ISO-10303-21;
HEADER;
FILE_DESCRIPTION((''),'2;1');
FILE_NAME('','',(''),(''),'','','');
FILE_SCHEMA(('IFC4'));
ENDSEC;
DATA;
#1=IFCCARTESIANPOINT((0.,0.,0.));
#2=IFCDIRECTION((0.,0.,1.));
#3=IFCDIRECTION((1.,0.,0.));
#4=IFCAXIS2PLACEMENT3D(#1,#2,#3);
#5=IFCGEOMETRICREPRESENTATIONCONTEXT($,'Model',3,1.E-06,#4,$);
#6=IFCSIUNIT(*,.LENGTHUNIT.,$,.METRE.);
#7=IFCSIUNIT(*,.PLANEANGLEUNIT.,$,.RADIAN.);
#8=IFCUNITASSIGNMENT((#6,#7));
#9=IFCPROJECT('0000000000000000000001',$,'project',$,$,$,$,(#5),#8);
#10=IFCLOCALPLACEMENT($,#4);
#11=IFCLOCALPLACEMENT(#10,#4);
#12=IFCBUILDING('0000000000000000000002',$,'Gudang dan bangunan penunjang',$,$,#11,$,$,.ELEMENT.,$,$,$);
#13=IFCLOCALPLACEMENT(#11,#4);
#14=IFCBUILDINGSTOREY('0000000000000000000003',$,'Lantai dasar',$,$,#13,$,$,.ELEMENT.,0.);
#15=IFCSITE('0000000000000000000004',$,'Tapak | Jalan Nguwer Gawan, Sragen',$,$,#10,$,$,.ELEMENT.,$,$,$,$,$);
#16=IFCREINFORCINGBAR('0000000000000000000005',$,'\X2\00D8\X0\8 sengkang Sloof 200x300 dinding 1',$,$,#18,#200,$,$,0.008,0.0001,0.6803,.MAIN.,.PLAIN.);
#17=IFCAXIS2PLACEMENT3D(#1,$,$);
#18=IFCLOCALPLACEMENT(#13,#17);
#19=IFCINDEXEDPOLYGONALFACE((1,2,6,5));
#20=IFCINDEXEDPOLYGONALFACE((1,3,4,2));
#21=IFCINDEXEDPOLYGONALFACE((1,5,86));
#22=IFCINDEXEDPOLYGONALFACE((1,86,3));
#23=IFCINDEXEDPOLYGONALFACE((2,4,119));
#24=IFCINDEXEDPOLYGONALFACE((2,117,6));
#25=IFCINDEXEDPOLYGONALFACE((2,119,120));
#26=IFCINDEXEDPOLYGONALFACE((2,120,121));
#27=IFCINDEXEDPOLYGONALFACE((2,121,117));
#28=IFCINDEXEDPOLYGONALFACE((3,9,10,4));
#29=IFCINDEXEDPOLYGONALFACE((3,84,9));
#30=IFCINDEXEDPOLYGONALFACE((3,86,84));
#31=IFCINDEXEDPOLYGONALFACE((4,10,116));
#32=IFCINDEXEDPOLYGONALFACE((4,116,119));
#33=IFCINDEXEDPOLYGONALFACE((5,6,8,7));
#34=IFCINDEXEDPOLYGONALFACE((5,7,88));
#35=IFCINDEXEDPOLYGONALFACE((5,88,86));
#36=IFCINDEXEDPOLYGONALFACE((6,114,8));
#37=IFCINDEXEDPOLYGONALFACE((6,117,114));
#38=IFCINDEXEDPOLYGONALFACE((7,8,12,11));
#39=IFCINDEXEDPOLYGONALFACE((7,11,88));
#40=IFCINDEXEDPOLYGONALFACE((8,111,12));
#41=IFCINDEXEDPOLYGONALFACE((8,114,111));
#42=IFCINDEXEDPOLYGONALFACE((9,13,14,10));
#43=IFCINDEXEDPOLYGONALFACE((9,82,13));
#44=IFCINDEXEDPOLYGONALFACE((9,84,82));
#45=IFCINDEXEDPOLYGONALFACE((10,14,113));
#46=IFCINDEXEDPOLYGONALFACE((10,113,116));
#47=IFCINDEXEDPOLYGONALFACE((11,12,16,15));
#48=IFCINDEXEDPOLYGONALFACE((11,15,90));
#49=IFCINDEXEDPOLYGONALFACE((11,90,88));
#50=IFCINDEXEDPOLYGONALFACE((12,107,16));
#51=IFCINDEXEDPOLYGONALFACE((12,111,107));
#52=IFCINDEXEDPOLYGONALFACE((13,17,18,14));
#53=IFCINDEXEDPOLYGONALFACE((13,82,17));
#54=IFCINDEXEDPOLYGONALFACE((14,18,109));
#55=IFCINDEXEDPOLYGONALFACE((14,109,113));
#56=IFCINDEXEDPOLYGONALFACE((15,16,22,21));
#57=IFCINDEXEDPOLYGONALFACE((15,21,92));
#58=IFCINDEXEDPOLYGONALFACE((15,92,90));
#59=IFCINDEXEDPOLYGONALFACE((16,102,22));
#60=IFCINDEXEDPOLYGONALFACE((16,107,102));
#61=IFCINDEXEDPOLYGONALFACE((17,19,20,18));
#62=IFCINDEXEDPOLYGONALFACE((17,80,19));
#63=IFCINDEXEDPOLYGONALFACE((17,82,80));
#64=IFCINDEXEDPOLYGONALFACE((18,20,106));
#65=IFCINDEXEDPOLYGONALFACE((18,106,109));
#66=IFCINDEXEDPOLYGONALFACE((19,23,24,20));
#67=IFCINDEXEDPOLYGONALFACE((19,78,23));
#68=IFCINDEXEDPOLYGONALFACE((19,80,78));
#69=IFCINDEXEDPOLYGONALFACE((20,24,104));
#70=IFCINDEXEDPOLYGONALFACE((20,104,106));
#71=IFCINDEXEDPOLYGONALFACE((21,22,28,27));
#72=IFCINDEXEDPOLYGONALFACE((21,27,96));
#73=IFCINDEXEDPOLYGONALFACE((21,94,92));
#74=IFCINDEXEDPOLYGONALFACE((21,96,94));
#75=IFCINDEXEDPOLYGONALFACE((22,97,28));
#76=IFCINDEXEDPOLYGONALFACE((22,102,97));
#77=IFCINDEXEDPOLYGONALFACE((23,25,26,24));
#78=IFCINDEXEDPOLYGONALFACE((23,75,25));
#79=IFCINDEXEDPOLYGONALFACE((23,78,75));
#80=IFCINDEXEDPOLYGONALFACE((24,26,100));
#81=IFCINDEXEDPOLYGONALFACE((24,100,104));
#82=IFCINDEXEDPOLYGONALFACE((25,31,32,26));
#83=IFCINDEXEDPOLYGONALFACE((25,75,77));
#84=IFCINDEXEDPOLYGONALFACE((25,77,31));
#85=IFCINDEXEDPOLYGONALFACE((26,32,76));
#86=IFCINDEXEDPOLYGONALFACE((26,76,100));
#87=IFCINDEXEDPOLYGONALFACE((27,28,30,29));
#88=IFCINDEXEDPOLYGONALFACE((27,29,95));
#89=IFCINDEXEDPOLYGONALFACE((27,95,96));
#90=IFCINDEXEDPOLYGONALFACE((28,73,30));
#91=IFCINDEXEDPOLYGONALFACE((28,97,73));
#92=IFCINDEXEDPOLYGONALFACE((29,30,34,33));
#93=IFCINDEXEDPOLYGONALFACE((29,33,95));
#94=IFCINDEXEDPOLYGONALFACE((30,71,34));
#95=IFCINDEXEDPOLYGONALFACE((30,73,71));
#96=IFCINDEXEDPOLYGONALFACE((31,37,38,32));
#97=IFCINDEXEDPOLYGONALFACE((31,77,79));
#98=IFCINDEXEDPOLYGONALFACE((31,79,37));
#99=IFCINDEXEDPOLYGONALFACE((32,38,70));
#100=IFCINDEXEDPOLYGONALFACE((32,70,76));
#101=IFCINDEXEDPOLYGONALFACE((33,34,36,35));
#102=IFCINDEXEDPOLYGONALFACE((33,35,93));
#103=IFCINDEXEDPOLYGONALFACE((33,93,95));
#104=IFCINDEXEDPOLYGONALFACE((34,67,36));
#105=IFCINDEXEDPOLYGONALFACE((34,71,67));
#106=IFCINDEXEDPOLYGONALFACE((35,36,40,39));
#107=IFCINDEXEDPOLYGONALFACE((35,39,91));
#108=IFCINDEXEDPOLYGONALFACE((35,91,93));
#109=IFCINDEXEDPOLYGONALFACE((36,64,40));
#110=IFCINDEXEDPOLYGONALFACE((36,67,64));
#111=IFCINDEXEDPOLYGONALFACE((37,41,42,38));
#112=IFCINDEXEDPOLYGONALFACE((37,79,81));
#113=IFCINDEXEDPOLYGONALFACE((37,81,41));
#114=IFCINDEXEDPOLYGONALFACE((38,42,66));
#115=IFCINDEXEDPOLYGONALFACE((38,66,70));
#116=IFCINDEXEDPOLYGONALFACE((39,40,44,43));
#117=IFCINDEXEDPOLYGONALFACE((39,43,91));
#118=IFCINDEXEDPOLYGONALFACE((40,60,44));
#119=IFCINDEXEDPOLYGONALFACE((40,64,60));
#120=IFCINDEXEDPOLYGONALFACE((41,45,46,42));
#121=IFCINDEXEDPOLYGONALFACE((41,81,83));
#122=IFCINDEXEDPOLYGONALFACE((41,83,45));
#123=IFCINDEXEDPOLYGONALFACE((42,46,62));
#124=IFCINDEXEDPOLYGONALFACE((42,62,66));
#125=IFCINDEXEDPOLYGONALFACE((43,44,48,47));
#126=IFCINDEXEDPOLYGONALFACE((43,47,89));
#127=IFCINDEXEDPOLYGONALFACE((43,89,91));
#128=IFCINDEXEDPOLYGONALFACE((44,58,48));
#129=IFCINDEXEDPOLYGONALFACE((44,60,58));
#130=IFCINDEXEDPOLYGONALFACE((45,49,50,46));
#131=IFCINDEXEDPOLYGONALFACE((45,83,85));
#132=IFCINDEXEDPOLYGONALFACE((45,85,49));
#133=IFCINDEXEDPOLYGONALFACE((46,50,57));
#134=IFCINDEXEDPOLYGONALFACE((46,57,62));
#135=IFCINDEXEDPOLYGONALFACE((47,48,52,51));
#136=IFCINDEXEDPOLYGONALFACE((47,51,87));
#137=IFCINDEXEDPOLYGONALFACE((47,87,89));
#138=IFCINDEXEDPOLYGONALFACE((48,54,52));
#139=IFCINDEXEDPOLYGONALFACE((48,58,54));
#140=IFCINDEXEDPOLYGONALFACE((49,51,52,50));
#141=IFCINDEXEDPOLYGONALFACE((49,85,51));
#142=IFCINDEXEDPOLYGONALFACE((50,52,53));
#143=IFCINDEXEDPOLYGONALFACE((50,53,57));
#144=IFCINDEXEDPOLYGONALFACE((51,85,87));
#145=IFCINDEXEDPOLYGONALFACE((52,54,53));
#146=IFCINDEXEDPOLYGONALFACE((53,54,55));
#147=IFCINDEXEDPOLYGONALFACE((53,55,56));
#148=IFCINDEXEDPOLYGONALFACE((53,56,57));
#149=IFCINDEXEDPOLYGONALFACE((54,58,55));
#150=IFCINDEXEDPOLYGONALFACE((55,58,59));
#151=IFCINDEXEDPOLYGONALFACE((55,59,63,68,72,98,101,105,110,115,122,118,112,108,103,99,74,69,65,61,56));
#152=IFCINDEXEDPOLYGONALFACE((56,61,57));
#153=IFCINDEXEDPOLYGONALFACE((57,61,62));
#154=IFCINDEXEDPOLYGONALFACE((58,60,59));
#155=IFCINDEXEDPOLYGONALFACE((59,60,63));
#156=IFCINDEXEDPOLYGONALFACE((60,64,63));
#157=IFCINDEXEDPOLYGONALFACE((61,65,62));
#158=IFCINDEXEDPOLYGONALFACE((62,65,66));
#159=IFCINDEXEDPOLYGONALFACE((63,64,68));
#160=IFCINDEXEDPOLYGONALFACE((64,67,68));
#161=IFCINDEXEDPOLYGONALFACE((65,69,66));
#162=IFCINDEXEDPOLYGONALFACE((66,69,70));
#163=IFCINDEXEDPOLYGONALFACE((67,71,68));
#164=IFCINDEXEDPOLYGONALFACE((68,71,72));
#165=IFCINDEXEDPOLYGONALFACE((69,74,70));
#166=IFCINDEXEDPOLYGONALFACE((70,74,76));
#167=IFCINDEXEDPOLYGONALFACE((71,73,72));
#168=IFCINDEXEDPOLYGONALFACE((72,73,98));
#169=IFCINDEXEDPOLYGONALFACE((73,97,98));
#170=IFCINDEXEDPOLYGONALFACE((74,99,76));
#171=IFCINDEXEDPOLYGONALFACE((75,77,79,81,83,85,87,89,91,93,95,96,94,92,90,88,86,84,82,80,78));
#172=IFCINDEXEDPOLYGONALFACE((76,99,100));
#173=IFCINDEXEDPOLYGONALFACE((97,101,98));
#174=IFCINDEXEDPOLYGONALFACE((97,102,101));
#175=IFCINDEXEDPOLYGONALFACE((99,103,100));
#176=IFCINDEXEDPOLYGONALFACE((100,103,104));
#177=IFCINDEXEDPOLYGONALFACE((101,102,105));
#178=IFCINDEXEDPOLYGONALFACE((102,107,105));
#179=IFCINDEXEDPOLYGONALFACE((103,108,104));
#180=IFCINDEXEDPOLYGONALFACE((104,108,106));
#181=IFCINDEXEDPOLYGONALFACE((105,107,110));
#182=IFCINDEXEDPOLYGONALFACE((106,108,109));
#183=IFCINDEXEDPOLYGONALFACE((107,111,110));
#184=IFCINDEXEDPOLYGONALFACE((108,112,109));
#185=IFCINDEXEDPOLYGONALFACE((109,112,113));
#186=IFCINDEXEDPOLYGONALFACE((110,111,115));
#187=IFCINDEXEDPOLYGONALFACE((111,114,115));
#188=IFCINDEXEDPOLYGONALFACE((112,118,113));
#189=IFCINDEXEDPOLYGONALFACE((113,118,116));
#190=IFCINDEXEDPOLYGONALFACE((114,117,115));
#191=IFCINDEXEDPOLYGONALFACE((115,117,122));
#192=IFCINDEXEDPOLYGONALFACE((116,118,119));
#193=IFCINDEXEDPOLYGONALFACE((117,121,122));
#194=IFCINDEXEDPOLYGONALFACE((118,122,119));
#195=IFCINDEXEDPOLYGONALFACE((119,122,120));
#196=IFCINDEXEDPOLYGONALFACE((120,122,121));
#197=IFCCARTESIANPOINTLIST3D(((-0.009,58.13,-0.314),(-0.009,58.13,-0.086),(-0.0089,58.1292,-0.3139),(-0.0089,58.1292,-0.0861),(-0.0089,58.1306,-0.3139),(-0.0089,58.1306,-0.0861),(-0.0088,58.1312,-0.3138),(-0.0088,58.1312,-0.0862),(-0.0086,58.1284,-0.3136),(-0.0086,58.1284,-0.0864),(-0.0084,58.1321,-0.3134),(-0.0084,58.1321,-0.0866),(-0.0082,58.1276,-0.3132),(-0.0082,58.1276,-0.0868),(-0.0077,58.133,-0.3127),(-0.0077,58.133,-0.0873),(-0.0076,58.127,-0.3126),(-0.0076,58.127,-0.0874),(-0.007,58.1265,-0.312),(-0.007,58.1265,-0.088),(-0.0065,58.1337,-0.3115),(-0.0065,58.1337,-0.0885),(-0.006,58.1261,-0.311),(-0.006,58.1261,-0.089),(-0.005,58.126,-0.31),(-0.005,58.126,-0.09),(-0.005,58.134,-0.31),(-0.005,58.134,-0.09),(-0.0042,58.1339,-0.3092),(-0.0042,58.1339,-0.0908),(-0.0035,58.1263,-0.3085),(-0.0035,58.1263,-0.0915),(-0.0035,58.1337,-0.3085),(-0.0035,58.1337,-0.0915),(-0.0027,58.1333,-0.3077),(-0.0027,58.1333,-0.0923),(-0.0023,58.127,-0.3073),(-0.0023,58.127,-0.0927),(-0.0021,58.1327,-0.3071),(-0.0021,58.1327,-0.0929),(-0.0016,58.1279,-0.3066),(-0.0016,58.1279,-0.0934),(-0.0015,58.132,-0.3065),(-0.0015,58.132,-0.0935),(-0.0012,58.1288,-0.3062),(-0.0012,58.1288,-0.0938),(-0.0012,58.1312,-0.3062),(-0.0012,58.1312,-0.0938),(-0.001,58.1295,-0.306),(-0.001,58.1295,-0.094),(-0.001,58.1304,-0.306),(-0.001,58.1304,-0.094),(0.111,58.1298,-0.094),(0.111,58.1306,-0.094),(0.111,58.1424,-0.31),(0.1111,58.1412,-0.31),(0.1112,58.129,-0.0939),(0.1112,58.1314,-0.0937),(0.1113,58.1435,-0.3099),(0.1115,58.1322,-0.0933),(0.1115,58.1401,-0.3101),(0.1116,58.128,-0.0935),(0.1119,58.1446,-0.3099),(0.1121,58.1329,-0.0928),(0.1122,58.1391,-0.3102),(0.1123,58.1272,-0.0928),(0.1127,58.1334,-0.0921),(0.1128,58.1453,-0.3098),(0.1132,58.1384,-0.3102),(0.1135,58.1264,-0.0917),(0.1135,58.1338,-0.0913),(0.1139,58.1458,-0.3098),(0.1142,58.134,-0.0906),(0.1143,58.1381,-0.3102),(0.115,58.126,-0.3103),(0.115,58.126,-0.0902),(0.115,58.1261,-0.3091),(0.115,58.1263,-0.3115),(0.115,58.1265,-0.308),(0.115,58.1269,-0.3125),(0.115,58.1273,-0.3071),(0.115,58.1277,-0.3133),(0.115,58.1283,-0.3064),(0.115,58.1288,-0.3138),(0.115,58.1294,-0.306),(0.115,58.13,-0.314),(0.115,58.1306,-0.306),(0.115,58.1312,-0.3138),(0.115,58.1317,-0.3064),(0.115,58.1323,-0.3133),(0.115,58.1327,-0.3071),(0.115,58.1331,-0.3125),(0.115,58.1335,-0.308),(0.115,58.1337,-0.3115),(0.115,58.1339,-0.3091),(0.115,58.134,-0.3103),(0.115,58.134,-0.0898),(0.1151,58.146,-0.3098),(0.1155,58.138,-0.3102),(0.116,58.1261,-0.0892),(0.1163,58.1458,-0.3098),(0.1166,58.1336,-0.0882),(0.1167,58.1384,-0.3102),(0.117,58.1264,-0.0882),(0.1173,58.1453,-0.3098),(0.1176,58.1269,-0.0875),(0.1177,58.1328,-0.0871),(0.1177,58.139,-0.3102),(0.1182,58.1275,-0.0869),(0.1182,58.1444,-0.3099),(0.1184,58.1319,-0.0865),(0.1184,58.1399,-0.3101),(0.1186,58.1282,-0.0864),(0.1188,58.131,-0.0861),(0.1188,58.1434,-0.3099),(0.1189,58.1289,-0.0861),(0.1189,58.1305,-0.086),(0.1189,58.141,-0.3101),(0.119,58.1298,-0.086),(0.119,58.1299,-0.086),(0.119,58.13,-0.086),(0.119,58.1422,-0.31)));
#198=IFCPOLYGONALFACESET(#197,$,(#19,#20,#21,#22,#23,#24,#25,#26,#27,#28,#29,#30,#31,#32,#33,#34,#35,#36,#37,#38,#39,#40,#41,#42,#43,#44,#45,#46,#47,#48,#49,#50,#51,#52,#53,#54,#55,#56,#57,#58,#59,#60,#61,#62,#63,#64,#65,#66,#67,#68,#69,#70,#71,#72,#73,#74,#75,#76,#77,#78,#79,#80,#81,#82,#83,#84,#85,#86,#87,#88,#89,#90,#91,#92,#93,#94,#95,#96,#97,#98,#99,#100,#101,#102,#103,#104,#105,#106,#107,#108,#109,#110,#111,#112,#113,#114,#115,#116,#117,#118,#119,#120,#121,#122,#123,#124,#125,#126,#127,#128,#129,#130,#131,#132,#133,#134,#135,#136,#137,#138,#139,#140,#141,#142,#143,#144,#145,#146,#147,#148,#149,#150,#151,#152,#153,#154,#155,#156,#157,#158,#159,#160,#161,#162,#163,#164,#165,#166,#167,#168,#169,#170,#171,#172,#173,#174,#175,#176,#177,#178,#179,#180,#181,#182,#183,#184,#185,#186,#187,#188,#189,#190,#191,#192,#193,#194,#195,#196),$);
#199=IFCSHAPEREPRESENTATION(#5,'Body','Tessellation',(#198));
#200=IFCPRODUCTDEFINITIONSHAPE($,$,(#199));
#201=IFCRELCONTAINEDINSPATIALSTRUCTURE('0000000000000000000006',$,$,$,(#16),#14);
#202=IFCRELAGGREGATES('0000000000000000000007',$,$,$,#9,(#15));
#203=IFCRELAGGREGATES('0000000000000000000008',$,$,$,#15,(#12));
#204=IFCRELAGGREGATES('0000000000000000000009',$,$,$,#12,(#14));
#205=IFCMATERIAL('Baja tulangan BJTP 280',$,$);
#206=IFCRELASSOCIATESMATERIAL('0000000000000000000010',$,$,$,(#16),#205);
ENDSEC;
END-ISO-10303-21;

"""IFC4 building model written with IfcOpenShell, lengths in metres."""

from ifc_helpers import new_model, entity, si_unit, origin_with_axes, place, context, project, spatial, material, element, save


model = new_model("IFC4")

# Units and contexts
model_context = context("Model", 3, precision=1e-06, world=origin_with_axes())
ifc_project = project(units=[si_unit("LENGTHUNIT", "METRE"), si_unit("PLANEANGLEUNIT", "RADIAN")], contexts=[model_context])

# Site, building, storey
site_placement = place(None, origin_with_axes())
site = spatial("IfcSite", under=ifc_project, at=site_placement, Name="Tapak | Jalan Nguwer Gawan, Sragen", CompositionType="ELEMENT")
building_placement = place(site_placement, origin_with_axes())
building = spatial("IfcBuilding", under=site, at=building_placement, Name="Gudang dan bangunan penunjang", CompositionType="ELEMENT")
storey_placement = place(building_placement, origin_with_axes())
storey = spatial("IfcBuildingStorey", under=building, at=storey_placement, Name="Lantai dasar", CompositionType="ELEMENT", Elevation=0.0)

# Shared definitions
placement = place(None, origin_with_axes())

# Reinforcing bar
ifc_material_1 = material(Name="Baja tulangan BJTP 280")
element("IfcReinforcingBar", 1, at=placement, inside=storey, material=ifc_material_1, Name="Ø8 sengkang Sloof 200x300 dinding 1", BarLength=0.6803, BarSurface="PLAIN", CrossSectionArea=0.0001, NominalDiameter=0.008, PredefinedType="MAIN", context=model_context, shape_type="AdvancedSweptSolid", body=[
    entity("IfcSweptDiskSolid", entity("IfcPolyline", [entity("IfcCartesianPoint", [0.115, 58.13, -0.31]), entity("IfcCartesianPoint", [-0.005, 58.13, -0.31]), entity("IfcCartesianPoint", [-0.005, 58.13, -0.09]), entity("IfcCartesianPoint", [0.115, 58.13, -0.09]), entity("IfcCartesianPoint", [0.115, 58.142, -0.31])]), 0.004),
])

save(model, "model.ifc")
